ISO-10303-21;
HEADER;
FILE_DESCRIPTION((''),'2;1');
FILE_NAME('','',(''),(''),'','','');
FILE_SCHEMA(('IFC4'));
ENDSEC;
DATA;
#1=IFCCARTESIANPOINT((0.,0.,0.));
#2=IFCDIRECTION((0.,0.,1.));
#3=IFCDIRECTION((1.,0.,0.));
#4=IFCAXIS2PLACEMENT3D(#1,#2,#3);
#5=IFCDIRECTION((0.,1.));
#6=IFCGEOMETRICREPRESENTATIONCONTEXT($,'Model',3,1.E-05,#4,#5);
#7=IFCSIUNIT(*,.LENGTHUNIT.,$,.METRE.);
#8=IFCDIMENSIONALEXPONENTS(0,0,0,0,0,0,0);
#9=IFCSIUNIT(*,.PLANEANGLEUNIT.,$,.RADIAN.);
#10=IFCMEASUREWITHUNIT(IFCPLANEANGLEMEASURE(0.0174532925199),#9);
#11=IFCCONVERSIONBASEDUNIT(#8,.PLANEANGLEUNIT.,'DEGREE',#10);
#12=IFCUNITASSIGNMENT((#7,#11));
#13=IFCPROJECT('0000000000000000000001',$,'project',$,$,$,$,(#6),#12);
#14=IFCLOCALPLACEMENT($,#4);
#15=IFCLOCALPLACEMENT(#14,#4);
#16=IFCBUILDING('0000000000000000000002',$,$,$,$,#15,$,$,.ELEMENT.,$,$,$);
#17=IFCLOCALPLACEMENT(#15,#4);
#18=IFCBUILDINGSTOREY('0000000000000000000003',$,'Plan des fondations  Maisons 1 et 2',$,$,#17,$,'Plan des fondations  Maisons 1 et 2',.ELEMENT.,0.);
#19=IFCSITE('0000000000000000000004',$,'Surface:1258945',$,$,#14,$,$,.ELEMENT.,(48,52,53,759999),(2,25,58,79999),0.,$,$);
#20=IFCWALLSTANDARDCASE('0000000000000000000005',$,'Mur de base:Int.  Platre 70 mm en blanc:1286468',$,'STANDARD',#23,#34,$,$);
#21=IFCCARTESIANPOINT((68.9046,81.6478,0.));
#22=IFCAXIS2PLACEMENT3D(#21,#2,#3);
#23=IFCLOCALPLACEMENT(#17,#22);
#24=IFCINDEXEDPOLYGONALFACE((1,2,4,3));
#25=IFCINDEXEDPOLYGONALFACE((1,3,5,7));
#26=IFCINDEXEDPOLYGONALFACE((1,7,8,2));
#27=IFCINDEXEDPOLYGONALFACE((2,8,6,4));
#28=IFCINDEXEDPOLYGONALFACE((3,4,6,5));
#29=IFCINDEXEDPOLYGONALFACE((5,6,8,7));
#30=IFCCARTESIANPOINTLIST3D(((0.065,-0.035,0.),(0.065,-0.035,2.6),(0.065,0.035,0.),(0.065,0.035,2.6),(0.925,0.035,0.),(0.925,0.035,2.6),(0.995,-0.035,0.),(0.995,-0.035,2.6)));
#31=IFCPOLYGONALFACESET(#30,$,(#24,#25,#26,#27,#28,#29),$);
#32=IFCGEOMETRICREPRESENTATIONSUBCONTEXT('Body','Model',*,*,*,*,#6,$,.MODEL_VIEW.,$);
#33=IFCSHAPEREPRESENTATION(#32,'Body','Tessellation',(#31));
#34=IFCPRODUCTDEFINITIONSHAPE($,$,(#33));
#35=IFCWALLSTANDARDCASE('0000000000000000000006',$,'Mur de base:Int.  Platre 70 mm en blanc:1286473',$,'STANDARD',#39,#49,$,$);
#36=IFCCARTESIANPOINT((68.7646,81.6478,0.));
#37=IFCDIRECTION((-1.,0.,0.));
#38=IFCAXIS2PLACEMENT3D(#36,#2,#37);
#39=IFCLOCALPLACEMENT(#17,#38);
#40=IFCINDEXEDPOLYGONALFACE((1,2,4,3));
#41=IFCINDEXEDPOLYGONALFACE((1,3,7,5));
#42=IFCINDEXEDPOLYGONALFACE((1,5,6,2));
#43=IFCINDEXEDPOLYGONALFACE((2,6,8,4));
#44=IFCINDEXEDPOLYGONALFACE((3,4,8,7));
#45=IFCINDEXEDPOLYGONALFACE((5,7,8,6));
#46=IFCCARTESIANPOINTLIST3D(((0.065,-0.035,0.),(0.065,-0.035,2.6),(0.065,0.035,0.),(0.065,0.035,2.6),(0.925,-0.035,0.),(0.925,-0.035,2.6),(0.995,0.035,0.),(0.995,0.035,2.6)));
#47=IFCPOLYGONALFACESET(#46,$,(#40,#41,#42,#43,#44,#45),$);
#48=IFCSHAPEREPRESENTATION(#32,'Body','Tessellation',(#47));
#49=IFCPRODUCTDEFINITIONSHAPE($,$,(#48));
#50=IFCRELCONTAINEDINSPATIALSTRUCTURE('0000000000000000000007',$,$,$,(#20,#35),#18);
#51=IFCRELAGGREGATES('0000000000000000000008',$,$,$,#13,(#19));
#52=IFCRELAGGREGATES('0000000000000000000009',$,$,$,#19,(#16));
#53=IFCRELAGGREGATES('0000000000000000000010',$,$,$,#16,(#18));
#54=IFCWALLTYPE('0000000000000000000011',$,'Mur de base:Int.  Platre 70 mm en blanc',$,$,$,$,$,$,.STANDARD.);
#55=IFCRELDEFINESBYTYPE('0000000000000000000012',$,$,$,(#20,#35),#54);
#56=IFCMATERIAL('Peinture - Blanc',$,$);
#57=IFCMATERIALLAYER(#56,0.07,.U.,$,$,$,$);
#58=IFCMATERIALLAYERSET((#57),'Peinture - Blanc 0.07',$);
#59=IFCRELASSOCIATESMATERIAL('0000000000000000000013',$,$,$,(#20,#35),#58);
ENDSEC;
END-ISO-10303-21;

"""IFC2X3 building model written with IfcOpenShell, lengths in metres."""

from ifc_helpers import new_model, entity, si_unit, converted_unit, direction, frame, origin_with_axes, place, context, subcontext, project, spatial, polyline, outline, extrude, material, layer, layer_set, layer_usage, type_object, element, save


model = new_model("IFC2X3")

# Units and contexts
model_context = context("Model", 3, precision=1e-05, world=origin_with_axes(), true_north=direction((0.0, 1.0)))
body_context = subcontext(model_context, "Body", "Model", "MODEL_VIEW")
ifc_project = project(units=[si_unit("LENGTHUNIT", "METRE"), converted_unit("PLANEANGLEUNIT", "DEGREE", entity("IfcPlaneAngleMeasure", 0.0174532925199), si_unit("PLANEANGLEUNIT", "RADIAN"), dimensions=[0, 0, 0, 0, 0, 0, 0])], contexts=[model_context])

# Site, building, storey
site_placement = place(None, origin_with_axes())
site = spatial("IfcSite", under=ifc_project, at=site_placement, Name="Surface:1258945", CompositionType="ELEMENT", RefLatitude=(48, 52, 53, 759999), RefLongitude=(2, 25, 58, 79999), RefElevation=0.0)
building_placement = place(site_placement, origin_with_axes())
building = spatial("IfcBuilding", under=site, at=building_placement, CompositionType="ELEMENT")
storey_placement = place(building_placement, origin_with_axes())
storey = spatial("IfcBuildingStorey", under=building, at=storey_placement, Name="Plan des fondations  Maisons 1 et 2", LongName="Plan des fondations  Maisons 1 et 2", CompositionType="ELEMENT", Elevation=0.0)

# Shared definitions
ifc_material_1 = material(Name="Peinture - Blanc")

# Shared definitions
ifc_layer_1 = layer(ifc_material_1, 0.07, ventilated="UNKNOWN")
ifc_layer_set_1 = layer_set([ifc_layer_1], Name="Peinture - Blanc 0.07")
wall_type_1 = type_object("IfcWallType", Name="Mur de base:Int.  Platre 70 mm en blanc", PredefinedType="STANDARD")

# Walls
ifc_layer_usage_1 = layer_usage(ifc_layer_set_1, "AXIS2", "POSITIVE", -0.035)
wall_1_placement = place(storey_placement, frame((68.9046, 81.6478, 0.0), z_axis=(0.0, 0.0, 1.0), x_axis=(1.0, 0.0, 0.0)))
element("IfcWallStandardCase", 1, at=wall_1_placement, inside=storey, type_object=wall_type_1, material=ifc_layer_usage_1, Name="Mur de base:Int.  Platre 70 mm en blanc:1286468", ObjectType="STANDARD", context=body_context, shape_type="SweptSolid", body=[
    extrude(outline(polyline([(0.065, -0.035), (0.995, -0.035), (0.925, 0.035), (0.065, 0.035), (0.065, -0.035)])), origin_with_axes(), (0.0, 0.0, 1.0), 2.6),
])
ifc_layer_usage_2 = layer_usage(ifc_layer_set_1, "AXIS2", "POSITIVE", -0.035)
wall_2_placement = place(storey_placement, frame((68.7646, 81.6478, 0.0), z_axis=(0.0, 0.0, 1.0), x_axis=(-1.0, 0.0, 0.0)))
element("IfcWallStandardCase", 2, at=wall_2_placement, inside=storey, type_object=wall_type_1, material=ifc_layer_usage_2, Name="Mur de base:Int.  Platre 70 mm en blanc:1286473", ObjectType="STANDARD", context=body_context, shape_type="SweptSolid", body=[
    extrude(outline(polyline([(0.065, -0.035), (0.925, -0.035), (0.995, 0.035), (0.065, 0.035), (0.065, -0.035)])), origin_with_axes(), (0.0, 0.0, 1.0), 2.6),
])

save(model, "model.ifc")
